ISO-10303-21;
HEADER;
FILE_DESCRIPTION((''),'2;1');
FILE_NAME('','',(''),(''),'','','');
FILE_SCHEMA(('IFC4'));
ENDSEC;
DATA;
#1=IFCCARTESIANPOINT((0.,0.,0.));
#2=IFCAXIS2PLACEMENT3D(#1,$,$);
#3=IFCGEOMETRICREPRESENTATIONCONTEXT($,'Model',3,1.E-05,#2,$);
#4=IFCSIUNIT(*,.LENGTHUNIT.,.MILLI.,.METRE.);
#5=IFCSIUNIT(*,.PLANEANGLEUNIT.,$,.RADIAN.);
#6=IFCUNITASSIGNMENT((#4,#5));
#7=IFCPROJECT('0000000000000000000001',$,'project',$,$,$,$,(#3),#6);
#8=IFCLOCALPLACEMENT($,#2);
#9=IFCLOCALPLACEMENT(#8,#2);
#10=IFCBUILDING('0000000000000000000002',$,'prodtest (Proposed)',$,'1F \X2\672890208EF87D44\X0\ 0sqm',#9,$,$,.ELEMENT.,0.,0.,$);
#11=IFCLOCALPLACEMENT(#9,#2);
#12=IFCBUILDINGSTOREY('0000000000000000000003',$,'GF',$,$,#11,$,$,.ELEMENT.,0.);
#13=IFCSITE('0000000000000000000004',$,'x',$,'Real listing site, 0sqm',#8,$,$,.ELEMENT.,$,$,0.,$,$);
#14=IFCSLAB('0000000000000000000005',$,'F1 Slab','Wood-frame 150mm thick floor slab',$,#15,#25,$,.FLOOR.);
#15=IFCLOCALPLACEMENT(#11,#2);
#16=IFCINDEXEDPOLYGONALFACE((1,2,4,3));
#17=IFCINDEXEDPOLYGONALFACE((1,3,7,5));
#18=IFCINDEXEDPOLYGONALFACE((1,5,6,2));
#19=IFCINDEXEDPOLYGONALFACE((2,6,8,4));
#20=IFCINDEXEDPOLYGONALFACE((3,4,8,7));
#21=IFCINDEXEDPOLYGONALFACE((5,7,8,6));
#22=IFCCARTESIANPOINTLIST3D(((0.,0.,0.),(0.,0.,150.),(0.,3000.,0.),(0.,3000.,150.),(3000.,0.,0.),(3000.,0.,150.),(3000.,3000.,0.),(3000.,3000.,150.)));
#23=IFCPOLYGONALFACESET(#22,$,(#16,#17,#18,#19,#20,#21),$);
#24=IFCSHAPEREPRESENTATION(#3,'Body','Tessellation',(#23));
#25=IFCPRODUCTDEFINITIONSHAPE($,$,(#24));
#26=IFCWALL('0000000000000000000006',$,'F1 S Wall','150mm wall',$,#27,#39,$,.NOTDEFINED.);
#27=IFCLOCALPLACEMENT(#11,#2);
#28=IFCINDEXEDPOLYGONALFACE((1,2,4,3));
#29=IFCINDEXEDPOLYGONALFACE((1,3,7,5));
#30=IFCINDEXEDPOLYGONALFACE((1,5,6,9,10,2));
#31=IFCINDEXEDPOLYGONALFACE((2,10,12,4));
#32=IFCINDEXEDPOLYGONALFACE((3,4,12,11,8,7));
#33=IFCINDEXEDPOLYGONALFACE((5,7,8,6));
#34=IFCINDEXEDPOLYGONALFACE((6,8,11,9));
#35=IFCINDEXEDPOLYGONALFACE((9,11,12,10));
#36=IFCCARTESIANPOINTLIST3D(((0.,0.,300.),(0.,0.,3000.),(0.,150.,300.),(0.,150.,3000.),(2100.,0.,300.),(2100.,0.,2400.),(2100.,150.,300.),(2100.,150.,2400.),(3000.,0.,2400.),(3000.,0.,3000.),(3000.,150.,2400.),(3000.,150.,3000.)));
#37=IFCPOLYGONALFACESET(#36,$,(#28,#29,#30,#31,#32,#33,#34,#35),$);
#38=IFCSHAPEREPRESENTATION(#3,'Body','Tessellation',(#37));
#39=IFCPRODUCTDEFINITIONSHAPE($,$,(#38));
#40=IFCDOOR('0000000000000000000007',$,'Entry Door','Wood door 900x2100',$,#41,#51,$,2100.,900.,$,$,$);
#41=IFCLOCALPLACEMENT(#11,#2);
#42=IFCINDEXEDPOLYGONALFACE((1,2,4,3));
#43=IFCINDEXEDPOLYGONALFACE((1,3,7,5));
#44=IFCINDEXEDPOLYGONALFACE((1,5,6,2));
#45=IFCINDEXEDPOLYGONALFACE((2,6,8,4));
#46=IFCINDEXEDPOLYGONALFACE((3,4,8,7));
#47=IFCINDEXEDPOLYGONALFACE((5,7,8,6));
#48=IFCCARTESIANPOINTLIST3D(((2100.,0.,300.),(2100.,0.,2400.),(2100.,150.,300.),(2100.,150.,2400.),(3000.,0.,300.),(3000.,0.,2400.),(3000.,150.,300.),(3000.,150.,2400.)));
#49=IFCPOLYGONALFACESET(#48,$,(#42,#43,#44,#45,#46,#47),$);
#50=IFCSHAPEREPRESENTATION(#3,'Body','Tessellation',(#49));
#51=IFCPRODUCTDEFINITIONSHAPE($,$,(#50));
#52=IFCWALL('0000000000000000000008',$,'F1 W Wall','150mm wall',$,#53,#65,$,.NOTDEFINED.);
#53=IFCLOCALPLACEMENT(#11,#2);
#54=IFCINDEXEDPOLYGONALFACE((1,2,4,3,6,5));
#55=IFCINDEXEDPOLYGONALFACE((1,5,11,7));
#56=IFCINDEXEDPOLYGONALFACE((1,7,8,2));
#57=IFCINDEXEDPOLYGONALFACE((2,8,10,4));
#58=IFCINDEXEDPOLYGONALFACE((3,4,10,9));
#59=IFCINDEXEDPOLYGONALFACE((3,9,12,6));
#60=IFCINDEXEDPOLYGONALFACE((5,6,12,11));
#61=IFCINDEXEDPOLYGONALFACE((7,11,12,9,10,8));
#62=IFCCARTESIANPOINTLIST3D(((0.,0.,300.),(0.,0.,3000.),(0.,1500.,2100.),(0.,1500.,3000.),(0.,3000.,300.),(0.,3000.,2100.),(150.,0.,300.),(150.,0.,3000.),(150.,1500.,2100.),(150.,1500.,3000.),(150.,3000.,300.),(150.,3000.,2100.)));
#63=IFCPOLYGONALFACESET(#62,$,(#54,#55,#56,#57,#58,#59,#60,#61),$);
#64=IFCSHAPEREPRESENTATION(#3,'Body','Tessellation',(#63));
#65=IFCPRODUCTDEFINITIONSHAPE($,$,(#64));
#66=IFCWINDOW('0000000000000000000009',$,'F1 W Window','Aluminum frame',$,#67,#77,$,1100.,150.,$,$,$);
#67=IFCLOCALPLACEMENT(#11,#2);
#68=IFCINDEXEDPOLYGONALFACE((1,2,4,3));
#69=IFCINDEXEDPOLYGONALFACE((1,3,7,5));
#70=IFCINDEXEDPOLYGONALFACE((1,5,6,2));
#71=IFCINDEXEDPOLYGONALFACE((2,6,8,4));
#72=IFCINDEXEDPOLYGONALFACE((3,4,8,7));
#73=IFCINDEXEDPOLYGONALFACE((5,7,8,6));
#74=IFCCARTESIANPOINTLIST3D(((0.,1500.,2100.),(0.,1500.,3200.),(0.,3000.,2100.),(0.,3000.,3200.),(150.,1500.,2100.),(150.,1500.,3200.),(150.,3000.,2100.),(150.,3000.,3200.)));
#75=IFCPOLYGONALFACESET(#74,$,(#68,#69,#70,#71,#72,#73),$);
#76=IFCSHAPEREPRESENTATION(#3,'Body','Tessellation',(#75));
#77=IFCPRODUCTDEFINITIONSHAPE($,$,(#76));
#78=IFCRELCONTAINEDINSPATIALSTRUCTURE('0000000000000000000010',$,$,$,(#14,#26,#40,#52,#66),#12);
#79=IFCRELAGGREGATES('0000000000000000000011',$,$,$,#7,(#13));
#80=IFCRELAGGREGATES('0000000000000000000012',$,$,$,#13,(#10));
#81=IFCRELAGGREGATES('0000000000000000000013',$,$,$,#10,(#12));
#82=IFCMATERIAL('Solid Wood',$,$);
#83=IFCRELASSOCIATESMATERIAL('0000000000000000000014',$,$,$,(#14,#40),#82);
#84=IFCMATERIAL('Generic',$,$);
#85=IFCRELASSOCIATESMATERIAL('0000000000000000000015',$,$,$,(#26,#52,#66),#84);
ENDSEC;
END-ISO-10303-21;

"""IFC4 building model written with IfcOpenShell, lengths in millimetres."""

from ifc_helpers import new_model, si_unit, frame, frame_2d, origin, place, context, project, spatial, rectangle, extrude, material, element, fill, save


model = new_model("IFC4")

# Units and contexts
model_context = context("Model", 3, precision=1e-05, world=origin())
ifc_project = project(units=[si_unit("LENGTHUNIT", "METRE", prefix="MILLI"), si_unit("PLANEANGLEUNIT", "RADIAN")], contexts=[model_context])

# Site, building, storey
site_placement = place(None, origin())
site = spatial("IfcSite", under=ifc_project, at=site_placement, Name="x", ObjectType="Real listing site, 0sqm", CompositionType="ELEMENT", RefElevation=0.0)
building_placement = place(site_placement, origin())
building = spatial("IfcBuilding", under=site, at=building_placement, Name="prodtest (Proposed)", ObjectType="1F 木造軸組 0sqm", CompositionType="ELEMENT", ElevationOfRefHeight=0.0, ElevationOfTerrain=0.0)
storey_placement = place(building_placement, origin())
storey = spatial("IfcBuildingStorey", under=building, at=storey_placement, Name="GF", CompositionType="ELEMENT", Elevation=0.0)

# Slab
ifc_material_1 = material(Name="Solid Wood")
slab_placement = place(storey_placement, origin())
element("IfcSlab", 1, at=slab_placement, inside=storey, material=ifc_material_1, Name="F1 Slab", Description="Wood-frame 150mm thick floor slab", PredefinedType="FLOOR", context=model_context, shape_type="SweptSolid", body=[
    extrude(rectangle(XDim=3000.0, YDim=3000.0, at=frame_2d((1500.0, 1500.0))), origin(), (0.0, 0.0, 1.0), 150.0),
])

# Shared definitions
ifc_material_2 = material(Name="Generic")

# Wall, opening, door
wall_1_placement = place(storey_placement, frame((0.0, 0.0, 150.0)))
wall_1 = element("IfcWall", 2, at=wall_1_placement, inside=storey, material=ifc_material_2, Name="F1 S Wall", Description="150mm wall", PredefinedType="NOTDEFINED", context=model_context, shape_type="SweptSolid", body=[
    extrude(rectangle(XDim=3000.0, YDim=150.0, at=frame_2d((1500.0, 75.0))), frame((0.0, 0.0, 150.0)), (0.0, 0.0, 1.0), 2700.0),
])
opening_1_placement = place(storey_placement, frame((1050.0, 0.0, 150.0)))
opening_1 = element("IfcOpeningElement", 3, at=opening_1_placement, cuts=wall_1, PredefinedType="NOTDEFINED", context=model_context, shape_type="SweptSolid", body=[
    extrude(rectangle(XDim=900.0, YDim=150.0, at=frame_2d((450.0, 75.0))), frame((1050.0, 0.0, 150.0)), (0.0, 0.0, 1.0), 2100.0),
])
door_placement = place(storey_placement, frame((1050.0, 0.0, 150.0)))
door = element("IfcDoor", 4, at=door_placement, inside=storey, material=ifc_material_1, Name="Entry Door", Description="Wood door 900x2100", OverallHeight=2100.0, OverallWidth=900.0, context=model_context, shape_type="SweptSolid", body=[
    extrude(rectangle(XDim=900.0, YDim=150.0, at=frame_2d((450.0, 75.0))), frame((1050.0, 0.0, 150.0)), (0.0, 0.0, 1.0), 2100.0),
])
fill(opening_1, door)

# Wall, opening, window
wall_2_placement = place(storey_placement, frame((0.0, 0.0, 150.0)))
wall_2 = element("IfcWall", 5, at=wall_2_placement, inside=storey, material=ifc_material_2, Name="F1 W Wall", Description="150mm wall", PredefinedType="NOTDEFINED", context=model_context, shape_type="SweptSolid", body=[
    extrude(rectangle(XDim=150.0, YDim=3000.0, at=frame_2d((75.0, 1500.0))), frame((0.0, 0.0, 150.0)), (0.0, 0.0, 1.0), 2700.0),
])
opening_2_placement = place(storey_placement, frame((0.0, 750.0, 1050.0)))
opening_2 = element("IfcOpeningElement", 6, at=opening_2_placement, cuts=wall_2, PredefinedType="NOTDEFINED", context=model_context, shape_type="SweptSolid", body=[
    extrude(rectangle(XDim=150.0, YDim=1500.0, at=frame_2d((75.0, 750.0))), frame((0.0, 750.0, 1050.0)), (0.0, 0.0, 1.0), 1100.0),
])
window_1_placement = place(storey_placement, frame((0.0, 750.0, 1050.0)))
window_1 = element("IfcWindow", 7, at=window_1_placement, inside=storey, material=ifc_material_2, Name="F1 W Window", Description="Aluminum frame", OverallHeight=1100.0, OverallWidth=150.0, context=model_context, shape_type="SweptSolid", body=[
    extrude(rectangle(XDim=150.0, YDim=1500.0, at=frame_2d((75.0, 750.0))), frame((0.0, 750.0, 1050.0)), (0.0, 0.0, 1.0), 1100.0),
])
fill(opening_2, window_1)

save(model, "model.ifc")
